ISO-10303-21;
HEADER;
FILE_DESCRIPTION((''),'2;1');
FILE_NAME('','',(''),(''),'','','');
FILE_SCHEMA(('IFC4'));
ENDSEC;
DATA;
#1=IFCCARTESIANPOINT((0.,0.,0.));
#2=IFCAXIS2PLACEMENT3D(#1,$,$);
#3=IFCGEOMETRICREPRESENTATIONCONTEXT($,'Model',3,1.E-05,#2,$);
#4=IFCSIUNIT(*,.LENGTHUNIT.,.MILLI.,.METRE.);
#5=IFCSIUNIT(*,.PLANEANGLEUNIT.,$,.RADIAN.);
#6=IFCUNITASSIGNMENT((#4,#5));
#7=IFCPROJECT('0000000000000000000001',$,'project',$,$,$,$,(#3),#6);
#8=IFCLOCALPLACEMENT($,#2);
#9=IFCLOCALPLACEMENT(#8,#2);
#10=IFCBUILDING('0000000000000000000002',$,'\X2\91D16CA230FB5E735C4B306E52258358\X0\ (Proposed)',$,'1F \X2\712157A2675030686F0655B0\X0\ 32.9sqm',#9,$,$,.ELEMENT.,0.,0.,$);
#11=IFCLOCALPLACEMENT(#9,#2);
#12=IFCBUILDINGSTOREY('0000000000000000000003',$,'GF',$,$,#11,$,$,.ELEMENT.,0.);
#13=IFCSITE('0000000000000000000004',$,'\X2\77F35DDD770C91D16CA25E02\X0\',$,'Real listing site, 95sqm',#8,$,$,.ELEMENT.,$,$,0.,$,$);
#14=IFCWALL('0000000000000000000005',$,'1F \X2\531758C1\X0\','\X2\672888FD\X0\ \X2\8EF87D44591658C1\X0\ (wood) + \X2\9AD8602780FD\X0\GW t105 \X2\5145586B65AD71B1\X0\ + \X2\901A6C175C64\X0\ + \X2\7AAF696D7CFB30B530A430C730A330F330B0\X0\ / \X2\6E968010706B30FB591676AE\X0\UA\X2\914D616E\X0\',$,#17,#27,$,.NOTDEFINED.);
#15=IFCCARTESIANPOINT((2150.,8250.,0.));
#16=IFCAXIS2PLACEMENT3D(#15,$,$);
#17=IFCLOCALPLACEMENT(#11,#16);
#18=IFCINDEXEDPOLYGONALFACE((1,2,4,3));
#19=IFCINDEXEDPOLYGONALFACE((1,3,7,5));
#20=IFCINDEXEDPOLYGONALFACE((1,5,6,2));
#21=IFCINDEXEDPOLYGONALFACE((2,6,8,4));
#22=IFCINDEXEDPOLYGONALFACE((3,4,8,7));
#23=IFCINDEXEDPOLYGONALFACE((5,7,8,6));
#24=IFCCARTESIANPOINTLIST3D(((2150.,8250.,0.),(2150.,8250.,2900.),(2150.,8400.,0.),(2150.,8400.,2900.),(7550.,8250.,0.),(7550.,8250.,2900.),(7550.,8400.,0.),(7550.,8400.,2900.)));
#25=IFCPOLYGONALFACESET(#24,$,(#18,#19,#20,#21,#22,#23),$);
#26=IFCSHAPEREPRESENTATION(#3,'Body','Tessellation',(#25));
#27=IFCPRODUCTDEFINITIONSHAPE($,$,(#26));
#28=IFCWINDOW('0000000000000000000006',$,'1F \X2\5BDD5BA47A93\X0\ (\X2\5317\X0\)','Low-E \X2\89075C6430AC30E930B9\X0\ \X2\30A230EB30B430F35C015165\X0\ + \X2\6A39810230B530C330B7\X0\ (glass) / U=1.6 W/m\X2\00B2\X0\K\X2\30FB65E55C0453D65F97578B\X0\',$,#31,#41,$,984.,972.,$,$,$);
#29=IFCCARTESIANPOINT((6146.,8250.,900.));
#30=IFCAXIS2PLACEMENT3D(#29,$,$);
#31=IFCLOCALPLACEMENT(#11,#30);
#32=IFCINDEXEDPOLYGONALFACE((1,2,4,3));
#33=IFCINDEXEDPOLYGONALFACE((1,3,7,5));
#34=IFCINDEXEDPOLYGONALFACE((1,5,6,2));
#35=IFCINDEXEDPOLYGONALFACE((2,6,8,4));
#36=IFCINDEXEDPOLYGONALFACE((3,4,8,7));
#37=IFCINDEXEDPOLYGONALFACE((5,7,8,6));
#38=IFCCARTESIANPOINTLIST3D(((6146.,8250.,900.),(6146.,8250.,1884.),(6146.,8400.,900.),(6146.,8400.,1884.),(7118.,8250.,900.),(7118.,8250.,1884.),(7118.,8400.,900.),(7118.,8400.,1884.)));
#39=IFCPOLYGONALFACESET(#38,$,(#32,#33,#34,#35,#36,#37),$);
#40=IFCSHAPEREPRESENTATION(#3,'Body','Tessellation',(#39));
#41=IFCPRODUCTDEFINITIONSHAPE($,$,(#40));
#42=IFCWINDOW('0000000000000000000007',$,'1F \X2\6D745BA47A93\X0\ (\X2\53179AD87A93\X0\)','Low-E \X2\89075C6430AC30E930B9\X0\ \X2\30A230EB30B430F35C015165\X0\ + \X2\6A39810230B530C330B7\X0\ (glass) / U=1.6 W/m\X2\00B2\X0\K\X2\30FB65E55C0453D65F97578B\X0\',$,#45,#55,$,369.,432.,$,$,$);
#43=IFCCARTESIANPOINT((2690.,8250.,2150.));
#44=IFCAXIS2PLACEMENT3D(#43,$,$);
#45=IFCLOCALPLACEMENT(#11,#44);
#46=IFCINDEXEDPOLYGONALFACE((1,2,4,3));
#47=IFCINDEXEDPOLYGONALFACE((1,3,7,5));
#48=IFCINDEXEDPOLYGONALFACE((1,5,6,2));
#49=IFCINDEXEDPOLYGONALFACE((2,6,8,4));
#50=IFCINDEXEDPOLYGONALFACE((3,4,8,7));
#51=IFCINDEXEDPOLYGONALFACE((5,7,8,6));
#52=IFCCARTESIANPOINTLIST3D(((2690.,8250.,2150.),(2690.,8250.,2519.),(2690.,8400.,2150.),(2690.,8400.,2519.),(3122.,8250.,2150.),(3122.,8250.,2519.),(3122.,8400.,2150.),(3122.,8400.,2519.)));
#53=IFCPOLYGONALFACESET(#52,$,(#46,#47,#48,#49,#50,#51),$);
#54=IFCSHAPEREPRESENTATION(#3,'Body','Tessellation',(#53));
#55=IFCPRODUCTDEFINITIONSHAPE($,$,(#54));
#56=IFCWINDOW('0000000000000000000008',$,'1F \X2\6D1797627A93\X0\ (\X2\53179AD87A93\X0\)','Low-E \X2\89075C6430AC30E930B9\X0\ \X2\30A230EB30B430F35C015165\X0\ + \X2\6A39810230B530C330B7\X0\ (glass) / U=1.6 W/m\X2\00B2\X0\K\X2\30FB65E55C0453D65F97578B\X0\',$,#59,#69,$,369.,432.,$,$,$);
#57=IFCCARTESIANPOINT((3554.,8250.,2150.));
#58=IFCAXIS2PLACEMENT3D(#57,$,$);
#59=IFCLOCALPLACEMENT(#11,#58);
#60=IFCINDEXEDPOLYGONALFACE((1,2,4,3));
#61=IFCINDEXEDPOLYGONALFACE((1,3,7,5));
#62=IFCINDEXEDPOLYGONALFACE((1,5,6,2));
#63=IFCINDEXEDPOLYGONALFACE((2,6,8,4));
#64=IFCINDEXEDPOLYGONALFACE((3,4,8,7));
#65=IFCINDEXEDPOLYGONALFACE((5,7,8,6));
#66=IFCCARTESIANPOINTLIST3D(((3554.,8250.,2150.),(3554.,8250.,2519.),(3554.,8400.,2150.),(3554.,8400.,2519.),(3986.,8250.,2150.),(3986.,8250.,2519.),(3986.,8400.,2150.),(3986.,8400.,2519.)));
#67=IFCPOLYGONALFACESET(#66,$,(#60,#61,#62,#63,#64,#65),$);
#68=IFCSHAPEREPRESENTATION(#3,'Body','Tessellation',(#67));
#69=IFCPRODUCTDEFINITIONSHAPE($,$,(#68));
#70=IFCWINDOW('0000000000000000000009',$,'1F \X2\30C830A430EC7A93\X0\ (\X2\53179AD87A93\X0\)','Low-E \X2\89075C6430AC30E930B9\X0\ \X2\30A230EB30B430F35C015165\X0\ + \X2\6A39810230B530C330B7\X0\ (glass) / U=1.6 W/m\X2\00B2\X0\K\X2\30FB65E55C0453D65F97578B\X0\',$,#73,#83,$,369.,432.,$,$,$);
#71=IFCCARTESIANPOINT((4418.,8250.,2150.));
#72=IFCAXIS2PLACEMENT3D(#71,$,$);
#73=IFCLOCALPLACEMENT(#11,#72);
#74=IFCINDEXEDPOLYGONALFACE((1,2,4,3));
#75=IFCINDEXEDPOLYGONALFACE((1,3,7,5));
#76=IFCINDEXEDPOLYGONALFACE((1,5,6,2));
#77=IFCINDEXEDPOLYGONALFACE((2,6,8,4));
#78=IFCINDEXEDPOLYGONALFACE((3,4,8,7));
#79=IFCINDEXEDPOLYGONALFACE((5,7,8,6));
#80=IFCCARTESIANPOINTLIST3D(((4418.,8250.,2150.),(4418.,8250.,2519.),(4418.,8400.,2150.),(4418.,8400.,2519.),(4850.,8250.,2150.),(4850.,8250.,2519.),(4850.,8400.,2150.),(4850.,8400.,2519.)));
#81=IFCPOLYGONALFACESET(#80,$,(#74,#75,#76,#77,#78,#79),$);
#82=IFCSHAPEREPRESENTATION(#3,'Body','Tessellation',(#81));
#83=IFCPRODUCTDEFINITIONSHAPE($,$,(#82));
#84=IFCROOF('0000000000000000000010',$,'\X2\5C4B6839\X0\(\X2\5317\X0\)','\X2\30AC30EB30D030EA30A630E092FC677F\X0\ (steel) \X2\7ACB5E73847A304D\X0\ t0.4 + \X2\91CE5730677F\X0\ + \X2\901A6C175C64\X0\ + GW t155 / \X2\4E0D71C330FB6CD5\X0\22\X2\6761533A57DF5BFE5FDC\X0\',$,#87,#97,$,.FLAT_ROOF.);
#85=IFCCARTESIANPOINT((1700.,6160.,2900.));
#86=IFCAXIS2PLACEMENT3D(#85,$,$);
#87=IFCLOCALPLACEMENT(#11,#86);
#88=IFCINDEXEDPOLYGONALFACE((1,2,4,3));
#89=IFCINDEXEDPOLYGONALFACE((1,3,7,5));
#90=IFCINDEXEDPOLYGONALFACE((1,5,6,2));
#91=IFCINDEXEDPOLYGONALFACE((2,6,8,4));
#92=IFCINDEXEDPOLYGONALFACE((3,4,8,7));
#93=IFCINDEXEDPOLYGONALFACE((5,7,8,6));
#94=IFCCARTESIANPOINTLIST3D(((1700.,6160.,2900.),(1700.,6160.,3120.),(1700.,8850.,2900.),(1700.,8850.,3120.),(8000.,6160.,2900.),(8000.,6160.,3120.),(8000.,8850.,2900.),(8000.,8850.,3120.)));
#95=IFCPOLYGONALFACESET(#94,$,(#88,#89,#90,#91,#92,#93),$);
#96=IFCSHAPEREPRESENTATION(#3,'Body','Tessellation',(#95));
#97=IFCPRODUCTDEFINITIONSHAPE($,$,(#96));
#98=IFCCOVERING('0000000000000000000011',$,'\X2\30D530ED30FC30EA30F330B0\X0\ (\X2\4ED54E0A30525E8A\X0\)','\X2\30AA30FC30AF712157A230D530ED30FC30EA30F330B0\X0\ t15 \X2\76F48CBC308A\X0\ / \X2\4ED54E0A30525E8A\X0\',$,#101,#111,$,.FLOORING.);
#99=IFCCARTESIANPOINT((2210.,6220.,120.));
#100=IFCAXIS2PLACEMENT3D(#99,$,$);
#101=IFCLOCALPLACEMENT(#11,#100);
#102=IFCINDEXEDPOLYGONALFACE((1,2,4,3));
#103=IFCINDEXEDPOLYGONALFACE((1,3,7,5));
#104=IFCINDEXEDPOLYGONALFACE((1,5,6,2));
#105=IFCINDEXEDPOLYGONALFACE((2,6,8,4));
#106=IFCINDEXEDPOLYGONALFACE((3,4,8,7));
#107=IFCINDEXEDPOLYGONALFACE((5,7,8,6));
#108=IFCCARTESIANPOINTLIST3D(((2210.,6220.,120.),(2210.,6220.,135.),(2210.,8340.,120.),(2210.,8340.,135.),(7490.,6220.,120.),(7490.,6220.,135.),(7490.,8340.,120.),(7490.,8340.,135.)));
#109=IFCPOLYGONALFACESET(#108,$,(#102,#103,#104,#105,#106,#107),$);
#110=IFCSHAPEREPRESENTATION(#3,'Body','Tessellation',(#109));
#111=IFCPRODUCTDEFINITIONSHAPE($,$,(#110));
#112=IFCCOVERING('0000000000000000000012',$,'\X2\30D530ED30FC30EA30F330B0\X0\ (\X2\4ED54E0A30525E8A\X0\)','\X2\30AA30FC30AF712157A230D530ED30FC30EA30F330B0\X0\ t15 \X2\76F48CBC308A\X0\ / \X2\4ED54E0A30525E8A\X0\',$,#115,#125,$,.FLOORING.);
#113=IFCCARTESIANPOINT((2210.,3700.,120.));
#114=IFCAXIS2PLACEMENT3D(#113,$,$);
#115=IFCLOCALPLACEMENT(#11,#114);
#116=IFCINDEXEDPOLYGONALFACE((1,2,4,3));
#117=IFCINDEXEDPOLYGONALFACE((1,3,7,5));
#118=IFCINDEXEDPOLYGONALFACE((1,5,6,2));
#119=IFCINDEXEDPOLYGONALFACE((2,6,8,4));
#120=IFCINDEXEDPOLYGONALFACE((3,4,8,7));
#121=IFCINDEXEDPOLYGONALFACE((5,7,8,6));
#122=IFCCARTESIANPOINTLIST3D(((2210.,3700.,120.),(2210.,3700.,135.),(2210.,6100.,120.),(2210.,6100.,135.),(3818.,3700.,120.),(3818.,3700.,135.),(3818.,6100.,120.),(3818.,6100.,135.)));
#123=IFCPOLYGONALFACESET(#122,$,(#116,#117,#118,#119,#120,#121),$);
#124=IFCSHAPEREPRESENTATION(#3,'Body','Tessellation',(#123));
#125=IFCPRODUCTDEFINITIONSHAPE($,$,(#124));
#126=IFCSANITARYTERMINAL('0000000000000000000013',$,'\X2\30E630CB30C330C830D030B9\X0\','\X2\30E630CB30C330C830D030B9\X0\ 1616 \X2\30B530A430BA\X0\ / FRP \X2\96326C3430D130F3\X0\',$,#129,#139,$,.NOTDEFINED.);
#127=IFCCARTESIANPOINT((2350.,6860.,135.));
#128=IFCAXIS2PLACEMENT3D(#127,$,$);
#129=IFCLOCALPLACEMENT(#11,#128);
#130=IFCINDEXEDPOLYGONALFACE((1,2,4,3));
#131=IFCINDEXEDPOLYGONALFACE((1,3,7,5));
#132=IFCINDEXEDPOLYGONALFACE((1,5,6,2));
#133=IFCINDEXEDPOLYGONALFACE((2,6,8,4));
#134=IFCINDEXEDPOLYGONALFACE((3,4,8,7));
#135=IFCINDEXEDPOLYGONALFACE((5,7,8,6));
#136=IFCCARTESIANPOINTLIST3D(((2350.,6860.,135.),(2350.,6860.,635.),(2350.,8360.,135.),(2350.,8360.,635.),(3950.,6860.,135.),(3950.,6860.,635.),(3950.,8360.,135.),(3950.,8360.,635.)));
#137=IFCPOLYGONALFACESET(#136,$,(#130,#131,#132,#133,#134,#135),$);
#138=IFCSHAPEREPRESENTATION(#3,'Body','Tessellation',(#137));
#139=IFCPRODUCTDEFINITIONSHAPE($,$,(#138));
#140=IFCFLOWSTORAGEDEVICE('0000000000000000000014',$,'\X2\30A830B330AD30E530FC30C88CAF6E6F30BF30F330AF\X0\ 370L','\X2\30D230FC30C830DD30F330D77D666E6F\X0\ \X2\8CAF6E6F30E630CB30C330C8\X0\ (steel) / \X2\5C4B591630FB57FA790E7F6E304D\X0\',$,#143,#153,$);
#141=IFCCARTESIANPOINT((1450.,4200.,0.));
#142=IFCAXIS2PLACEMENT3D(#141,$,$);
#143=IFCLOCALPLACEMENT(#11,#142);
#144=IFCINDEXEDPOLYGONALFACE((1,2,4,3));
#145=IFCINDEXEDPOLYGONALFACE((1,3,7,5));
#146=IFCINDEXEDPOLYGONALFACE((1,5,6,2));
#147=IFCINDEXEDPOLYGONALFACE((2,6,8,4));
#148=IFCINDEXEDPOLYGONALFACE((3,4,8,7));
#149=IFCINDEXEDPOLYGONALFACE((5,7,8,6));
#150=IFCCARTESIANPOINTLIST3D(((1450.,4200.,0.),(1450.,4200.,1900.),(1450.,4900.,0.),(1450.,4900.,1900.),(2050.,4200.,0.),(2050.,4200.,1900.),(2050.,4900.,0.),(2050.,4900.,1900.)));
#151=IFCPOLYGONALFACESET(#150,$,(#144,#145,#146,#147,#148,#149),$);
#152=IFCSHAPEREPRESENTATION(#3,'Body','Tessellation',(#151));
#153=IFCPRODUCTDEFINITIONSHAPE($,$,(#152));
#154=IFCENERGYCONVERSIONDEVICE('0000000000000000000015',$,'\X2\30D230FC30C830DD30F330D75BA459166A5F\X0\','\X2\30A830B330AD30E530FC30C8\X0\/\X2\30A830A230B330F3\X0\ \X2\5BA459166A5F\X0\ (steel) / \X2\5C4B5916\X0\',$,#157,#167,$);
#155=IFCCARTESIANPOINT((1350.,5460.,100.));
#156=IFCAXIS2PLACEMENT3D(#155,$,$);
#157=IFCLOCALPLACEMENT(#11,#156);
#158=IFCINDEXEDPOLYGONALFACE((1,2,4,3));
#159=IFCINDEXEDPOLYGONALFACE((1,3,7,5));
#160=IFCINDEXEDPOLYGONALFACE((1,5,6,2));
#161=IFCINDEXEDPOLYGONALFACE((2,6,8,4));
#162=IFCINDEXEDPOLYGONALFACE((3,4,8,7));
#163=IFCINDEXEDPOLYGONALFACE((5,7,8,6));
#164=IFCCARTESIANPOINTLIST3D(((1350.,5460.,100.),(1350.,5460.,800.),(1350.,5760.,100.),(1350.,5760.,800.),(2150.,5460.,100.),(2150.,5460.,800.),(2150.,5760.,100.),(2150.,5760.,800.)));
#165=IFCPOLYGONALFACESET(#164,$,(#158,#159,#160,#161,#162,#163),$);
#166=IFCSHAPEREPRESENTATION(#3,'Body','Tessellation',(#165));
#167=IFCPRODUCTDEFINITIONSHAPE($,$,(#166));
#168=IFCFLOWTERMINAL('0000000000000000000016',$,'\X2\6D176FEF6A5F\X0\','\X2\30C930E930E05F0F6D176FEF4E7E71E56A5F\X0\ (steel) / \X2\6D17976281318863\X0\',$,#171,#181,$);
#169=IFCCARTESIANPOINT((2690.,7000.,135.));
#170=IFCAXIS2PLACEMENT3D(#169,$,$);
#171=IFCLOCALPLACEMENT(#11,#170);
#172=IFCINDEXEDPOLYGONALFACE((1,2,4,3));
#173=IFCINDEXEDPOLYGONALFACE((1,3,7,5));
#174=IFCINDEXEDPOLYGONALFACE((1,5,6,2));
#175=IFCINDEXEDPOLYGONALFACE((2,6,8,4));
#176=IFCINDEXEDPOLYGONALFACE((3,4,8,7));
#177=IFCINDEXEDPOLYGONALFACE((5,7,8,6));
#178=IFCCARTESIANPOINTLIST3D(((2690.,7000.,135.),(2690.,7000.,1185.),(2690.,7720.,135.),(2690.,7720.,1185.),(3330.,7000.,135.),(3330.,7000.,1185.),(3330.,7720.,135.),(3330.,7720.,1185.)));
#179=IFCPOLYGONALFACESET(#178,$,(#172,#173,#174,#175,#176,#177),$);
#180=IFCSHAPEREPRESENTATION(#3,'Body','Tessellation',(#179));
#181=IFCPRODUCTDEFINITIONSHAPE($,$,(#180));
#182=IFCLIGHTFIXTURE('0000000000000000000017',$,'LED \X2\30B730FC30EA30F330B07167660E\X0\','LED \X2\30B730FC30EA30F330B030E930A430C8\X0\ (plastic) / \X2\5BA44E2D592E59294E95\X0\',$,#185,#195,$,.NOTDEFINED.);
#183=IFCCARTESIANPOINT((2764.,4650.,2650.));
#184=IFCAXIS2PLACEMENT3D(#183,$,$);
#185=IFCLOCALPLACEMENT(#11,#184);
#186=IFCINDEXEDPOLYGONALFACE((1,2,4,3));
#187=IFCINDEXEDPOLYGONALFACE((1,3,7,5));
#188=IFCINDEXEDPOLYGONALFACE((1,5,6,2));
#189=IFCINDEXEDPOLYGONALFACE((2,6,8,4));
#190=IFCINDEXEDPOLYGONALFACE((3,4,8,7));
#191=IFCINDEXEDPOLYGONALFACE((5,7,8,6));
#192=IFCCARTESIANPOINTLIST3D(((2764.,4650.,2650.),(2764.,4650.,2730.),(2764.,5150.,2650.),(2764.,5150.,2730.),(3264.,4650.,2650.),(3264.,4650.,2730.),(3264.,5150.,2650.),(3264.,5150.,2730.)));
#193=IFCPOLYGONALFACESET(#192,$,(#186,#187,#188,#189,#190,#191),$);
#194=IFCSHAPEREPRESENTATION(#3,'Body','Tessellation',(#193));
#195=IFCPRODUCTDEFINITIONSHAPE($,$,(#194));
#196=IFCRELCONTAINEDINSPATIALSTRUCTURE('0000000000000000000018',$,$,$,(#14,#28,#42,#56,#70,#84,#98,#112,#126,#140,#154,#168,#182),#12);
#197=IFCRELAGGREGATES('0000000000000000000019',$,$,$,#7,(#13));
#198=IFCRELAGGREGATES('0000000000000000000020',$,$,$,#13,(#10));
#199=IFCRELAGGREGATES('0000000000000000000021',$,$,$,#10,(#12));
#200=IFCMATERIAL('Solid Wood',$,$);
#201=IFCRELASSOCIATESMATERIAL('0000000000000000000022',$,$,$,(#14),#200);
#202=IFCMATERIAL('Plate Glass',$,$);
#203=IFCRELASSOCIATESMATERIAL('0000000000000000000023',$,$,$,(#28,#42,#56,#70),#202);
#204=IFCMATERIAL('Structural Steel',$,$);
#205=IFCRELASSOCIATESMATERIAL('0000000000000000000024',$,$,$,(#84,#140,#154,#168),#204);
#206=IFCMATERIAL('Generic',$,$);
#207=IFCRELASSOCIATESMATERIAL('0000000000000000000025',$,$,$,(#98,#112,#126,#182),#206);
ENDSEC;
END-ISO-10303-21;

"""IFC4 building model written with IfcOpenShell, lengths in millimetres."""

from ifc_helpers import new_model, si_unit, frame, frame_2d, origin, place, context, project, spatial, rectangle, extrude, material, element, fill, save


model = new_model("IFC4")

# Units and contexts
model_context = context("Model", 3, precision=1e-05, world=origin())
ifc_project = project(units=[si_unit("LENGTHUNIT", "METRE", prefix="MILLI"), si_unit("PLANEANGLEUNIT", "RADIAN")], contexts=[model_context])

# Site, building, storey
site_placement = place(None, origin())
site = spatial("IfcSite", under=ifc_project, at=site_placement, Name="石川県金沢市", ObjectType="Real listing site, 95sqm", CompositionType="ELEMENT", RefElevation=0.0)
building_placement = place(site_placement, origin())
building = spatial("IfcBuilding", under=site, at=building_placement, Name="金沢・平屋の別荘 (Proposed)", ObjectType="1F 無垢材と漆喰 32.9sqm", CompositionType="ELEMENT", ElevationOfRefHeight=0.0, ElevationOfTerrain=0.0)
storey_placement = place(building_placement, origin())
storey = spatial("IfcBuildingStorey", under=building, at=storey_placement, Name="GF", CompositionType="ELEMENT", Elevation=0.0)

# Shared definitions
ifc_material_1 = material(Name="Solid Wood")

# Wall, openings, windows
wall_1_placement = place(storey_placement, frame((2150.0, 8250.0, 0.0)))
wall_1 = element("IfcWall", 1, at=wall_1_placement, inside=storey, material=ifc_material_1, Name="1F 北壁", Description="木製 軸組外壁 (wood) + 高性能GW t105 充填断熱 + 通気層 + 窯業系サイディング / 準耐火・外皮UA配慮", PredefinedType="NOTDEFINED", context=model_context, shape_type="SweptSolid", body=[
    extrude(rectangle(XDim=5400.0, YDim=150.0, at=frame_2d((2700.0, 75.0))), frame((2150.0, 8250.0, 0.0)), (0.0, 0.0, 1.0), 2900.0),
])
opening_1_placement = place(storey_placement, frame((6146.0, 8250.0, 900.0)))
opening_1 = element("IfcOpeningElement", 2, at=opening_1_placement, cuts=wall_1, PredefinedType="NOTDEFINED", context=model_context, shape_type="SweptSolid", body=[
    extrude(rectangle(XDim=972.0, YDim=150.0, at=frame_2d((486.0, 75.0))), frame((6146.0, 8250.0, 900.0)), (0.0, 0.0, 1.0), 984.0),
])
opening_2_placement = place(storey_placement, frame((2690.0, 8250.0, 2150.0)))
opening_2 = element("IfcOpeningElement", 3, at=opening_2_placement, cuts=wall_1, PredefinedType="NOTDEFINED", context=model_context, shape_type="SweptSolid", body=[
    extrude(rectangle(XDim=432.0, YDim=150.0, at=frame_2d((216.0, 75.0))), frame((2690.0, 8250.0, 2150.0)), (0.0, 0.0, 1.0), 369.0),
])
opening_3_placement = place(storey_placement, frame((3554.0, 8250.0, 2150.0)))
opening_3 = element("IfcOpeningElement", 4, at=opening_3_placement, cuts=wall_1, PredefinedType="NOTDEFINED", context=model_context, shape_type="SweptSolid", body=[
    extrude(rectangle(XDim=432.0, YDim=150.0, at=frame_2d((216.0, 75.0))), frame((3554.0, 8250.0, 2150.0)), (0.0, 0.0, 1.0), 369.0),
])
opening_4_placement = place(storey_placement, frame((4418.0, 8250.0, 2150.0)))
opening_4 = element("IfcOpeningElement", 5, at=opening_4_placement, cuts=wall_1, PredefinedType="NOTDEFINED", context=model_context, shape_type="SweptSolid", body=[
    extrude(rectangle(XDim=432.0, YDim=150.0, at=frame_2d((216.0, 75.0))), frame((4418.0, 8250.0, 2150.0)), (0.0, 0.0, 1.0), 369.0),
])
ifc_material_2 = material(Name="Plate Glass")
window_1_placement = place(storey_placement, frame((6146.0, 8250.0, 900.0)))
window_1 = element("IfcWindow", 6, at=window_1_placement, inside=storey, material=ifc_material_2, Name="1F 寝室窓 (北)", Description="Low-E 複層ガラス アルゴン封入 + 樹脂サッシ (glass) / U=1.6 W/m²K・日射取得型", OverallHeight=984.0, OverallWidth=972.0, context=model_context, shape_type="SweptSolid", body=[
    extrude(rectangle(XDim=972.0, YDim=150.0, at=frame_2d((486.0, 75.0))), frame((6146.0, 8250.0, 900.0)), (0.0, 0.0, 1.0), 984.0),
])
fill(opening_1, window_1)
window_2_placement = place(storey_placement, frame((2690.0, 8250.0, 2150.0)))
window_2 = element("IfcWindow", 7, at=window_2_placement, inside=storey, material=ifc_material_2, Name="1F 浴室窓 (北高窓)", Description="Low-E 複層ガラス アルゴン封入 + 樹脂サッシ (glass) / U=1.6 W/m²K・日射取得型", OverallHeight=369.0, OverallWidth=432.0, context=model_context, shape_type="SweptSolid", body=[
    extrude(rectangle(XDim=432.0, YDim=150.0, at=frame_2d((216.0, 75.0))), frame((2690.0, 8250.0, 2150.0)), (0.0, 0.0, 1.0), 369.0),
])
fill(opening_2, window_2)
window_3_placement = place(storey_placement, frame((3554.0, 8250.0, 2150.0)))
window_3 = element("IfcWindow", 8, at=window_3_placement, inside=storey, material=ifc_material_2, Name="1F 洗面窓 (北高窓)", Description="Low-E 複層ガラス アルゴン封入 + 樹脂サッシ (glass) / U=1.6 W/m²K・日射取得型", OverallHeight=369.0, OverallWidth=432.0, context=model_context, shape_type="SweptSolid", body=[
    extrude(rectangle(XDim=432.0, YDim=150.0, at=frame_2d((216.0, 75.0))), frame((3554.0, 8250.0, 2150.0)), (0.0, 0.0, 1.0), 369.0),
])
fill(opening_3, window_3)
window_4_placement = place(storey_placement, frame((4418.0, 8250.0, 2150.0)))
window_4 = element("IfcWindow", 9, at=window_4_placement, inside=storey, material=ifc_material_2, Name="1F トイレ窓 (北高窓)", Description="Low-E 複層ガラス アルゴン封入 + 樹脂サッシ (glass) / U=1.6 W/m²K・日射取得型", OverallHeight=369.0, OverallWidth=432.0, context=model_context, shape_type="SweptSolid", body=[
    extrude(rectangle(XDim=432.0, YDim=150.0, at=frame_2d((216.0, 75.0))), frame((4418.0, 8250.0, 2150.0)), (0.0, 0.0, 1.0), 369.0),
])
fill(opening_4, window_4)

# Roof
ifc_material_3 = material(Name="Structural Steel")
roof_placement = place(storey_placement, frame((1700.0, 6160.0, 2900.0)))
element("IfcRoof", 10, at=roof_placement, inside=storey, material=ifc_material_3, Name="屋根(北)", Description="ガルバリウム鋼板 (steel) 立平葺き t0.4 + 野地板 + 通気層 + GW t155 / 不燃・法22条区域対応", PredefinedType="FLAT_ROOF", context=model_context, shape_type="SweptSolid", body=[
    extrude(rectangle(XDim=6300.0, YDim=2690.0, at=frame_2d((3150.0, 1345.0))), frame((1700.0, 6160.0, 2900.0)), (0.0, 0.0, 1.0), 220.0),
])

# Coverings
ifc_material_4 = material(Name="Generic")
covering_1_placement = place(storey_placement, frame((2210.0, 6220.0, 120.0)))
element("IfcCovering", 11, at=covering_1_placement, inside=storey, material=ifc_material_4, Name="フローリング (仕上げ床)", Description="オーク無垢フローリング t15 直貼り / 仕上げ床", PredefinedType="FLOORING", context=model_context, shape_type="SweptSolid", body=[
    extrude(rectangle(XDim=5280.0, YDim=2120.0, at=frame_2d((2640.0, 1060.0))), frame((2210.0, 6220.0, 120.0)), (0.0, 0.0, 1.0), 15.0),
])
covering_2_placement = place(storey_placement, frame((2210.0, 3700.0, 120.0)))
element("IfcCovering", 12, at=covering_2_placement, inside=storey, material=ifc_material_4, Name="フローリング (仕上げ床)", Description="オーク無垢フローリング t15 直貼り / 仕上げ床", PredefinedType="FLOORING", context=model_context, shape_type="SweptSolid", body=[
    extrude(rectangle(XDim=1608.0, YDim=2400.0, at=frame_2d((804.0, 1200.0))), frame((2210.0, 3700.0, 120.0)), (0.0, 0.0, 1.0), 15.0),
])

# Sanitary terminal
sanitary_terminal_placement = place(storey_placement, frame((2350.0, 6860.0, 135.0)))
element("IfcSanitaryTerminal", 13, at=sanitary_terminal_placement, inside=storey, material=ifc_material_4, Name="ユニットバス", Description="ユニットバス 1616 サイズ / FRP 防水パン", PredefinedType="NOTDEFINED", context=model_context, shape_type="SweptSolid", body=[
    extrude(rectangle(XDim=1600.0, YDim=1500.0, at=frame_2d((800.0, 750.0))), frame((2350.0, 6860.0, 135.0)), (0.0, 0.0, 1.0), 500.0),
])

# Flow storage device
flow_storage_device_placement = place(storey_placement, frame((1450.0, 4200.0, 0.0)))
element("IfcFlowStorageDevice", 14, at=flow_storage_device_placement, inside=storey, material=ifc_material_3, Name="エコキュート貯湯タンク 370L", Description="ヒートポンプ給湯 貯湯ユニット (steel) / 屋外・基礎置き", context=model_context, shape_type="SweptSolid", body=[
    extrude(rectangle(XDim=600.0, YDim=700.0, at=frame_2d((300.0, 350.0))), frame((1450.0, 4200.0, 0.0)), (0.0, 0.0, 1.0), 1900.0),
])

# Energy conversion device
energy_conversion_device_placement = place(storey_placement, frame((1350.0, 5460.0, 100.0)))
element("IfcEnergyConversionDevice", 15, at=energy_conversion_device_placement, inside=storey, material=ifc_material_3, Name="ヒートポンプ室外機", Description="エコキュート/エアコン 室外機 (steel) / 屋外", context=model_context, shape_type="SweptSolid", body=[
    extrude(rectangle(XDim=800.0, YDim=300.0, at=frame_2d((400.0, 150.0))), frame((1350.0, 5460.0, 100.0)), (0.0, 0.0, 1.0), 700.0),
])

# Flow terminal
flow_terminal_placement = place(storey_placement, frame((2690.0, 7000.0, 135.0)))
element("IfcFlowTerminal", 16, at=flow_terminal_placement, inside=storey, material=ifc_material_3, Name="洗濯機", Description="ドラム式洗濯乾燥機 (steel) / 洗面脱衣", context=model_context, shape_type="SweptSolid", body=[
    extrude(rectangle(XDim=640.0, YDim=720.0, at=frame_2d((320.0, 360.0))), frame((2690.0, 7000.0, 135.0)), (0.0, 0.0, 1.0), 1050.0),
])

# Light fixture
light_fixture_placement = place(storey_placement, frame((2764.0, 4650.0, 2650.0)))
element("IfcLightFixture", 17, at=light_fixture_placement, inside=storey, material=ifc_material_4, Name="LED シーリング照明", Description="LED シーリングライト (plastic) / 室中央天井", PredefinedType="NOTDEFINED", context=model_context, shape_type="SweptSolid", body=[
    extrude(rectangle(XDim=500.0, YDim=500.0, at=frame_2d((250.0, 250.0))), frame((2764.0, 4650.0, 2650.0)), (0.0, 0.0, 1.0), 80.0),
])

save(model, "model.ifc")
